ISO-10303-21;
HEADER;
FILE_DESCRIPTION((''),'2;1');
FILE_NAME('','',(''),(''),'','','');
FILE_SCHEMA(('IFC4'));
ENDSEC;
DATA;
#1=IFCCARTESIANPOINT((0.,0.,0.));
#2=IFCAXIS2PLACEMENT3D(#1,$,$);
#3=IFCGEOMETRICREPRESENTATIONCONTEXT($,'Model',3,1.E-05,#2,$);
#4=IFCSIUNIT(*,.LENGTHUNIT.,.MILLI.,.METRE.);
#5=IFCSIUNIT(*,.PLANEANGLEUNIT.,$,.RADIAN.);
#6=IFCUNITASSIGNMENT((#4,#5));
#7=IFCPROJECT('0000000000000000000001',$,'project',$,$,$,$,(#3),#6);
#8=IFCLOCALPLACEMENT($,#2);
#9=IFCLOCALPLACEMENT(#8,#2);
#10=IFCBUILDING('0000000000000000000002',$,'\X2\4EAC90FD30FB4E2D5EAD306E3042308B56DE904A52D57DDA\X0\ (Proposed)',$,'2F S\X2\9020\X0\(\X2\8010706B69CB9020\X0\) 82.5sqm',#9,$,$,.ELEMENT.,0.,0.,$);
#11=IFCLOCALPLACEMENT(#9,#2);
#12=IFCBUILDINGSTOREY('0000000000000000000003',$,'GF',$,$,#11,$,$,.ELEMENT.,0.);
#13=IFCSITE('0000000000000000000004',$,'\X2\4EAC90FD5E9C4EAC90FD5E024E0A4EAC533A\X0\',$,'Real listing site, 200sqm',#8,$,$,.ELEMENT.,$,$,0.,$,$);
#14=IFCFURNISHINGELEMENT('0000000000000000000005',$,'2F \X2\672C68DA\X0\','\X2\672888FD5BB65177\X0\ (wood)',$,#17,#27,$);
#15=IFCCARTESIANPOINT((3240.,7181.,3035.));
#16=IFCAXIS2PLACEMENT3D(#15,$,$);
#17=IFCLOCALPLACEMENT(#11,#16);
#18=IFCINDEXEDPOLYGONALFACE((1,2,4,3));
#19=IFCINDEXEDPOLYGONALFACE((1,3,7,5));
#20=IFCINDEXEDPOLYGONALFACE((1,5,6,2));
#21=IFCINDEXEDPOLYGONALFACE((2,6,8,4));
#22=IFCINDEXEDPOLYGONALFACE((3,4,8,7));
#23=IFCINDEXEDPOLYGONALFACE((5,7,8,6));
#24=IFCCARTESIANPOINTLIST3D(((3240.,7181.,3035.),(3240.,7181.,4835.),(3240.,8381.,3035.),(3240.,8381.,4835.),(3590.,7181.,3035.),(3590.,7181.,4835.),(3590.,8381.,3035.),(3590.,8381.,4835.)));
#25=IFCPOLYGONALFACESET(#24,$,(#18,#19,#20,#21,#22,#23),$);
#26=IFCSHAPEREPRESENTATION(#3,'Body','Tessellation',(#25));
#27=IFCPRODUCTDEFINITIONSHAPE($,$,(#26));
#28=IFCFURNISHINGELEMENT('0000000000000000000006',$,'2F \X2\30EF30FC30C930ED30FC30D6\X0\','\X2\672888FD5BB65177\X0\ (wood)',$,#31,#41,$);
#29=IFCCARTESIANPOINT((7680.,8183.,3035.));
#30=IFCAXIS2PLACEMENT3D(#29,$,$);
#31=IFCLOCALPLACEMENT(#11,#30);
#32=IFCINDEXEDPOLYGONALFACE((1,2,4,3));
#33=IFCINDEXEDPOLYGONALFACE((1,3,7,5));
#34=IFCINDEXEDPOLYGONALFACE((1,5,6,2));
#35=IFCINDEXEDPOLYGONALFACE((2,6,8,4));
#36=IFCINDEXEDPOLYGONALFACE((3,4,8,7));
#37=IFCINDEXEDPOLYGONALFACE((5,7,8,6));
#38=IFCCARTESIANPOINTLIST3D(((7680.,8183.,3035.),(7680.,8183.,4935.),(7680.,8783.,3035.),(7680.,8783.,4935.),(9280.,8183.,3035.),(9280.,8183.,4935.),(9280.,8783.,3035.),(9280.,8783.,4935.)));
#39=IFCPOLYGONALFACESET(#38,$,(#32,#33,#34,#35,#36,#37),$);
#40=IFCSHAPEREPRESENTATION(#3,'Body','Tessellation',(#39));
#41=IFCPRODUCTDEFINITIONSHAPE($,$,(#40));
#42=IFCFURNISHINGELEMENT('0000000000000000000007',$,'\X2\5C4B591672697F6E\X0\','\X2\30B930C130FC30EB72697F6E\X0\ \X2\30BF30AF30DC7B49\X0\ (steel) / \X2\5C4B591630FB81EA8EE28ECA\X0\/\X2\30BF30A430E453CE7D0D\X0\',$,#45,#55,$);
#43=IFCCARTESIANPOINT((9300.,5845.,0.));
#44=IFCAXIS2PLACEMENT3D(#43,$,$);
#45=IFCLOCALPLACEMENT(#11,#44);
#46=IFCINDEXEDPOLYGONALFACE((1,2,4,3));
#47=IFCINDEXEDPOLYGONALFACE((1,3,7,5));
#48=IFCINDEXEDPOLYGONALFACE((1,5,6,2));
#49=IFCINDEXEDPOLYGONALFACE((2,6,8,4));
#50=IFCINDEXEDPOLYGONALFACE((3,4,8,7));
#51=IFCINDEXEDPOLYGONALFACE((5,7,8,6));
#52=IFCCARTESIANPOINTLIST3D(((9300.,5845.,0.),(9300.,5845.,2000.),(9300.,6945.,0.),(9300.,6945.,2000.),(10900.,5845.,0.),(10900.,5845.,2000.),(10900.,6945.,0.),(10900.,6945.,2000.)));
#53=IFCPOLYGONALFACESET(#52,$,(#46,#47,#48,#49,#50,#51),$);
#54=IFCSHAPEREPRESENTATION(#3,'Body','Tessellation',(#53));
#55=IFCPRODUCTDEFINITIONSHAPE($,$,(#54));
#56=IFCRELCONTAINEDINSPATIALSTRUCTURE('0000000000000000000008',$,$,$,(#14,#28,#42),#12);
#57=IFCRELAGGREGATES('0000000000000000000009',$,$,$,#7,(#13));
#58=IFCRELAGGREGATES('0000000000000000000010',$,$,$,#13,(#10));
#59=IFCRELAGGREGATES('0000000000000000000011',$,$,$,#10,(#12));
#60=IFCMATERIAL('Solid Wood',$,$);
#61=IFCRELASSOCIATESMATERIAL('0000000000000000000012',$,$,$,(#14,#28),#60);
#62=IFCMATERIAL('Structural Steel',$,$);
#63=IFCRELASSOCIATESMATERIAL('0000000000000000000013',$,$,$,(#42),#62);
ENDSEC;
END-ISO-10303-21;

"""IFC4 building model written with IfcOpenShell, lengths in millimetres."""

from ifc_helpers import new_model, si_unit, frame, frame_2d, origin, place, context, project, spatial, rectangle, extrude, material, element, save


model = new_model("IFC4")

# Units and contexts
model_context = context("Model", 3, precision=1e-05, world=origin())
ifc_project = project(units=[si_unit("LENGTHUNIT", "METRE", prefix="MILLI"), si_unit("PLANEANGLEUNIT", "RADIAN")], contexts=[model_context])

# Site, building, storey
site_placement = place(None, origin())
site = spatial("IfcSite", under=ifc_project, at=site_placement, Name="京都府京都市上京区", ObjectType="Real listing site, 200sqm", CompositionType="ELEMENT", RefElevation=0.0)
building_placement = place(site_placement, origin())
building = spatial("IfcBuilding", under=site, at=building_placement, Name="京都・中庭のある回遊動線 (Proposed)", ObjectType="2F S造(耐火構造) 82.5sqm", CompositionType="ELEMENT", ElevationOfRefHeight=0.0, ElevationOfTerrain=0.0)
storey_placement = place(building_placement, origin())
storey = spatial("IfcBuildingStorey", under=building, at=storey_placement, Name="GF", CompositionType="ELEMENT", Elevation=0.0)

# Shared definitions
ifc_material_1 = material(Name="Solid Wood")

# Shared definitions
ifc_material_2 = material(Name="Structural Steel")

# Furnishing elements
furnishing_1_placement = place(storey_placement, frame((3240.0, 7181.0, 3035.0)))
element("IfcFurnishingElement", 1, at=furnishing_1_placement, inside=storey, material=ifc_material_1, Name="2F 本棚", Description="木製家具 (wood)", context=model_context, shape_type="SweptSolid", body=[
    extrude(rectangle(XDim=350.0, YDim=1200.0, at=frame_2d((175.0, 600.0))), frame((3240.0, 7181.0, 3035.0)), (0.0, 0.0, 1.0), 1800.0),
])
furnishing_2_placement = place(storey_placement, frame((7680.0, 8183.0, 3035.0)))
element("IfcFurnishingElement", 2, at=furnishing_2_placement, inside=storey, material=ifc_material_1, Name="2F ワードローブ", Description="木製家具 (wood)", context=model_context, shape_type="SweptSolid", body=[
    extrude(rectangle(XDim=1600.0, YDim=600.0, at=frame_2d((800.0, 300.0))), frame((7680.0, 8183.0, 3035.0)), (0.0, 0.0, 1.0), 1900.0),
])
furnishing_3_placement = place(storey_placement, frame((9300.0, 5845.0, 0.0)))
element("IfcFurnishingElement", 3, at=furnishing_3_placement, inside=storey, material=ifc_material_2, Name="屋外物置", Description="スチール物置 タクボ等 (steel) / 屋外・自転車/タイヤ収納", context=model_context, shape_type="SweptSolid", body=[
    extrude(rectangle(XDim=1600.0, YDim=1100.0, at=frame_2d((800.0, 550.0))), frame((9300.0, 5845.0, 0.0)), (0.0, 0.0, 1.0), 2000.0),
])

save(model, "model.ifc")
